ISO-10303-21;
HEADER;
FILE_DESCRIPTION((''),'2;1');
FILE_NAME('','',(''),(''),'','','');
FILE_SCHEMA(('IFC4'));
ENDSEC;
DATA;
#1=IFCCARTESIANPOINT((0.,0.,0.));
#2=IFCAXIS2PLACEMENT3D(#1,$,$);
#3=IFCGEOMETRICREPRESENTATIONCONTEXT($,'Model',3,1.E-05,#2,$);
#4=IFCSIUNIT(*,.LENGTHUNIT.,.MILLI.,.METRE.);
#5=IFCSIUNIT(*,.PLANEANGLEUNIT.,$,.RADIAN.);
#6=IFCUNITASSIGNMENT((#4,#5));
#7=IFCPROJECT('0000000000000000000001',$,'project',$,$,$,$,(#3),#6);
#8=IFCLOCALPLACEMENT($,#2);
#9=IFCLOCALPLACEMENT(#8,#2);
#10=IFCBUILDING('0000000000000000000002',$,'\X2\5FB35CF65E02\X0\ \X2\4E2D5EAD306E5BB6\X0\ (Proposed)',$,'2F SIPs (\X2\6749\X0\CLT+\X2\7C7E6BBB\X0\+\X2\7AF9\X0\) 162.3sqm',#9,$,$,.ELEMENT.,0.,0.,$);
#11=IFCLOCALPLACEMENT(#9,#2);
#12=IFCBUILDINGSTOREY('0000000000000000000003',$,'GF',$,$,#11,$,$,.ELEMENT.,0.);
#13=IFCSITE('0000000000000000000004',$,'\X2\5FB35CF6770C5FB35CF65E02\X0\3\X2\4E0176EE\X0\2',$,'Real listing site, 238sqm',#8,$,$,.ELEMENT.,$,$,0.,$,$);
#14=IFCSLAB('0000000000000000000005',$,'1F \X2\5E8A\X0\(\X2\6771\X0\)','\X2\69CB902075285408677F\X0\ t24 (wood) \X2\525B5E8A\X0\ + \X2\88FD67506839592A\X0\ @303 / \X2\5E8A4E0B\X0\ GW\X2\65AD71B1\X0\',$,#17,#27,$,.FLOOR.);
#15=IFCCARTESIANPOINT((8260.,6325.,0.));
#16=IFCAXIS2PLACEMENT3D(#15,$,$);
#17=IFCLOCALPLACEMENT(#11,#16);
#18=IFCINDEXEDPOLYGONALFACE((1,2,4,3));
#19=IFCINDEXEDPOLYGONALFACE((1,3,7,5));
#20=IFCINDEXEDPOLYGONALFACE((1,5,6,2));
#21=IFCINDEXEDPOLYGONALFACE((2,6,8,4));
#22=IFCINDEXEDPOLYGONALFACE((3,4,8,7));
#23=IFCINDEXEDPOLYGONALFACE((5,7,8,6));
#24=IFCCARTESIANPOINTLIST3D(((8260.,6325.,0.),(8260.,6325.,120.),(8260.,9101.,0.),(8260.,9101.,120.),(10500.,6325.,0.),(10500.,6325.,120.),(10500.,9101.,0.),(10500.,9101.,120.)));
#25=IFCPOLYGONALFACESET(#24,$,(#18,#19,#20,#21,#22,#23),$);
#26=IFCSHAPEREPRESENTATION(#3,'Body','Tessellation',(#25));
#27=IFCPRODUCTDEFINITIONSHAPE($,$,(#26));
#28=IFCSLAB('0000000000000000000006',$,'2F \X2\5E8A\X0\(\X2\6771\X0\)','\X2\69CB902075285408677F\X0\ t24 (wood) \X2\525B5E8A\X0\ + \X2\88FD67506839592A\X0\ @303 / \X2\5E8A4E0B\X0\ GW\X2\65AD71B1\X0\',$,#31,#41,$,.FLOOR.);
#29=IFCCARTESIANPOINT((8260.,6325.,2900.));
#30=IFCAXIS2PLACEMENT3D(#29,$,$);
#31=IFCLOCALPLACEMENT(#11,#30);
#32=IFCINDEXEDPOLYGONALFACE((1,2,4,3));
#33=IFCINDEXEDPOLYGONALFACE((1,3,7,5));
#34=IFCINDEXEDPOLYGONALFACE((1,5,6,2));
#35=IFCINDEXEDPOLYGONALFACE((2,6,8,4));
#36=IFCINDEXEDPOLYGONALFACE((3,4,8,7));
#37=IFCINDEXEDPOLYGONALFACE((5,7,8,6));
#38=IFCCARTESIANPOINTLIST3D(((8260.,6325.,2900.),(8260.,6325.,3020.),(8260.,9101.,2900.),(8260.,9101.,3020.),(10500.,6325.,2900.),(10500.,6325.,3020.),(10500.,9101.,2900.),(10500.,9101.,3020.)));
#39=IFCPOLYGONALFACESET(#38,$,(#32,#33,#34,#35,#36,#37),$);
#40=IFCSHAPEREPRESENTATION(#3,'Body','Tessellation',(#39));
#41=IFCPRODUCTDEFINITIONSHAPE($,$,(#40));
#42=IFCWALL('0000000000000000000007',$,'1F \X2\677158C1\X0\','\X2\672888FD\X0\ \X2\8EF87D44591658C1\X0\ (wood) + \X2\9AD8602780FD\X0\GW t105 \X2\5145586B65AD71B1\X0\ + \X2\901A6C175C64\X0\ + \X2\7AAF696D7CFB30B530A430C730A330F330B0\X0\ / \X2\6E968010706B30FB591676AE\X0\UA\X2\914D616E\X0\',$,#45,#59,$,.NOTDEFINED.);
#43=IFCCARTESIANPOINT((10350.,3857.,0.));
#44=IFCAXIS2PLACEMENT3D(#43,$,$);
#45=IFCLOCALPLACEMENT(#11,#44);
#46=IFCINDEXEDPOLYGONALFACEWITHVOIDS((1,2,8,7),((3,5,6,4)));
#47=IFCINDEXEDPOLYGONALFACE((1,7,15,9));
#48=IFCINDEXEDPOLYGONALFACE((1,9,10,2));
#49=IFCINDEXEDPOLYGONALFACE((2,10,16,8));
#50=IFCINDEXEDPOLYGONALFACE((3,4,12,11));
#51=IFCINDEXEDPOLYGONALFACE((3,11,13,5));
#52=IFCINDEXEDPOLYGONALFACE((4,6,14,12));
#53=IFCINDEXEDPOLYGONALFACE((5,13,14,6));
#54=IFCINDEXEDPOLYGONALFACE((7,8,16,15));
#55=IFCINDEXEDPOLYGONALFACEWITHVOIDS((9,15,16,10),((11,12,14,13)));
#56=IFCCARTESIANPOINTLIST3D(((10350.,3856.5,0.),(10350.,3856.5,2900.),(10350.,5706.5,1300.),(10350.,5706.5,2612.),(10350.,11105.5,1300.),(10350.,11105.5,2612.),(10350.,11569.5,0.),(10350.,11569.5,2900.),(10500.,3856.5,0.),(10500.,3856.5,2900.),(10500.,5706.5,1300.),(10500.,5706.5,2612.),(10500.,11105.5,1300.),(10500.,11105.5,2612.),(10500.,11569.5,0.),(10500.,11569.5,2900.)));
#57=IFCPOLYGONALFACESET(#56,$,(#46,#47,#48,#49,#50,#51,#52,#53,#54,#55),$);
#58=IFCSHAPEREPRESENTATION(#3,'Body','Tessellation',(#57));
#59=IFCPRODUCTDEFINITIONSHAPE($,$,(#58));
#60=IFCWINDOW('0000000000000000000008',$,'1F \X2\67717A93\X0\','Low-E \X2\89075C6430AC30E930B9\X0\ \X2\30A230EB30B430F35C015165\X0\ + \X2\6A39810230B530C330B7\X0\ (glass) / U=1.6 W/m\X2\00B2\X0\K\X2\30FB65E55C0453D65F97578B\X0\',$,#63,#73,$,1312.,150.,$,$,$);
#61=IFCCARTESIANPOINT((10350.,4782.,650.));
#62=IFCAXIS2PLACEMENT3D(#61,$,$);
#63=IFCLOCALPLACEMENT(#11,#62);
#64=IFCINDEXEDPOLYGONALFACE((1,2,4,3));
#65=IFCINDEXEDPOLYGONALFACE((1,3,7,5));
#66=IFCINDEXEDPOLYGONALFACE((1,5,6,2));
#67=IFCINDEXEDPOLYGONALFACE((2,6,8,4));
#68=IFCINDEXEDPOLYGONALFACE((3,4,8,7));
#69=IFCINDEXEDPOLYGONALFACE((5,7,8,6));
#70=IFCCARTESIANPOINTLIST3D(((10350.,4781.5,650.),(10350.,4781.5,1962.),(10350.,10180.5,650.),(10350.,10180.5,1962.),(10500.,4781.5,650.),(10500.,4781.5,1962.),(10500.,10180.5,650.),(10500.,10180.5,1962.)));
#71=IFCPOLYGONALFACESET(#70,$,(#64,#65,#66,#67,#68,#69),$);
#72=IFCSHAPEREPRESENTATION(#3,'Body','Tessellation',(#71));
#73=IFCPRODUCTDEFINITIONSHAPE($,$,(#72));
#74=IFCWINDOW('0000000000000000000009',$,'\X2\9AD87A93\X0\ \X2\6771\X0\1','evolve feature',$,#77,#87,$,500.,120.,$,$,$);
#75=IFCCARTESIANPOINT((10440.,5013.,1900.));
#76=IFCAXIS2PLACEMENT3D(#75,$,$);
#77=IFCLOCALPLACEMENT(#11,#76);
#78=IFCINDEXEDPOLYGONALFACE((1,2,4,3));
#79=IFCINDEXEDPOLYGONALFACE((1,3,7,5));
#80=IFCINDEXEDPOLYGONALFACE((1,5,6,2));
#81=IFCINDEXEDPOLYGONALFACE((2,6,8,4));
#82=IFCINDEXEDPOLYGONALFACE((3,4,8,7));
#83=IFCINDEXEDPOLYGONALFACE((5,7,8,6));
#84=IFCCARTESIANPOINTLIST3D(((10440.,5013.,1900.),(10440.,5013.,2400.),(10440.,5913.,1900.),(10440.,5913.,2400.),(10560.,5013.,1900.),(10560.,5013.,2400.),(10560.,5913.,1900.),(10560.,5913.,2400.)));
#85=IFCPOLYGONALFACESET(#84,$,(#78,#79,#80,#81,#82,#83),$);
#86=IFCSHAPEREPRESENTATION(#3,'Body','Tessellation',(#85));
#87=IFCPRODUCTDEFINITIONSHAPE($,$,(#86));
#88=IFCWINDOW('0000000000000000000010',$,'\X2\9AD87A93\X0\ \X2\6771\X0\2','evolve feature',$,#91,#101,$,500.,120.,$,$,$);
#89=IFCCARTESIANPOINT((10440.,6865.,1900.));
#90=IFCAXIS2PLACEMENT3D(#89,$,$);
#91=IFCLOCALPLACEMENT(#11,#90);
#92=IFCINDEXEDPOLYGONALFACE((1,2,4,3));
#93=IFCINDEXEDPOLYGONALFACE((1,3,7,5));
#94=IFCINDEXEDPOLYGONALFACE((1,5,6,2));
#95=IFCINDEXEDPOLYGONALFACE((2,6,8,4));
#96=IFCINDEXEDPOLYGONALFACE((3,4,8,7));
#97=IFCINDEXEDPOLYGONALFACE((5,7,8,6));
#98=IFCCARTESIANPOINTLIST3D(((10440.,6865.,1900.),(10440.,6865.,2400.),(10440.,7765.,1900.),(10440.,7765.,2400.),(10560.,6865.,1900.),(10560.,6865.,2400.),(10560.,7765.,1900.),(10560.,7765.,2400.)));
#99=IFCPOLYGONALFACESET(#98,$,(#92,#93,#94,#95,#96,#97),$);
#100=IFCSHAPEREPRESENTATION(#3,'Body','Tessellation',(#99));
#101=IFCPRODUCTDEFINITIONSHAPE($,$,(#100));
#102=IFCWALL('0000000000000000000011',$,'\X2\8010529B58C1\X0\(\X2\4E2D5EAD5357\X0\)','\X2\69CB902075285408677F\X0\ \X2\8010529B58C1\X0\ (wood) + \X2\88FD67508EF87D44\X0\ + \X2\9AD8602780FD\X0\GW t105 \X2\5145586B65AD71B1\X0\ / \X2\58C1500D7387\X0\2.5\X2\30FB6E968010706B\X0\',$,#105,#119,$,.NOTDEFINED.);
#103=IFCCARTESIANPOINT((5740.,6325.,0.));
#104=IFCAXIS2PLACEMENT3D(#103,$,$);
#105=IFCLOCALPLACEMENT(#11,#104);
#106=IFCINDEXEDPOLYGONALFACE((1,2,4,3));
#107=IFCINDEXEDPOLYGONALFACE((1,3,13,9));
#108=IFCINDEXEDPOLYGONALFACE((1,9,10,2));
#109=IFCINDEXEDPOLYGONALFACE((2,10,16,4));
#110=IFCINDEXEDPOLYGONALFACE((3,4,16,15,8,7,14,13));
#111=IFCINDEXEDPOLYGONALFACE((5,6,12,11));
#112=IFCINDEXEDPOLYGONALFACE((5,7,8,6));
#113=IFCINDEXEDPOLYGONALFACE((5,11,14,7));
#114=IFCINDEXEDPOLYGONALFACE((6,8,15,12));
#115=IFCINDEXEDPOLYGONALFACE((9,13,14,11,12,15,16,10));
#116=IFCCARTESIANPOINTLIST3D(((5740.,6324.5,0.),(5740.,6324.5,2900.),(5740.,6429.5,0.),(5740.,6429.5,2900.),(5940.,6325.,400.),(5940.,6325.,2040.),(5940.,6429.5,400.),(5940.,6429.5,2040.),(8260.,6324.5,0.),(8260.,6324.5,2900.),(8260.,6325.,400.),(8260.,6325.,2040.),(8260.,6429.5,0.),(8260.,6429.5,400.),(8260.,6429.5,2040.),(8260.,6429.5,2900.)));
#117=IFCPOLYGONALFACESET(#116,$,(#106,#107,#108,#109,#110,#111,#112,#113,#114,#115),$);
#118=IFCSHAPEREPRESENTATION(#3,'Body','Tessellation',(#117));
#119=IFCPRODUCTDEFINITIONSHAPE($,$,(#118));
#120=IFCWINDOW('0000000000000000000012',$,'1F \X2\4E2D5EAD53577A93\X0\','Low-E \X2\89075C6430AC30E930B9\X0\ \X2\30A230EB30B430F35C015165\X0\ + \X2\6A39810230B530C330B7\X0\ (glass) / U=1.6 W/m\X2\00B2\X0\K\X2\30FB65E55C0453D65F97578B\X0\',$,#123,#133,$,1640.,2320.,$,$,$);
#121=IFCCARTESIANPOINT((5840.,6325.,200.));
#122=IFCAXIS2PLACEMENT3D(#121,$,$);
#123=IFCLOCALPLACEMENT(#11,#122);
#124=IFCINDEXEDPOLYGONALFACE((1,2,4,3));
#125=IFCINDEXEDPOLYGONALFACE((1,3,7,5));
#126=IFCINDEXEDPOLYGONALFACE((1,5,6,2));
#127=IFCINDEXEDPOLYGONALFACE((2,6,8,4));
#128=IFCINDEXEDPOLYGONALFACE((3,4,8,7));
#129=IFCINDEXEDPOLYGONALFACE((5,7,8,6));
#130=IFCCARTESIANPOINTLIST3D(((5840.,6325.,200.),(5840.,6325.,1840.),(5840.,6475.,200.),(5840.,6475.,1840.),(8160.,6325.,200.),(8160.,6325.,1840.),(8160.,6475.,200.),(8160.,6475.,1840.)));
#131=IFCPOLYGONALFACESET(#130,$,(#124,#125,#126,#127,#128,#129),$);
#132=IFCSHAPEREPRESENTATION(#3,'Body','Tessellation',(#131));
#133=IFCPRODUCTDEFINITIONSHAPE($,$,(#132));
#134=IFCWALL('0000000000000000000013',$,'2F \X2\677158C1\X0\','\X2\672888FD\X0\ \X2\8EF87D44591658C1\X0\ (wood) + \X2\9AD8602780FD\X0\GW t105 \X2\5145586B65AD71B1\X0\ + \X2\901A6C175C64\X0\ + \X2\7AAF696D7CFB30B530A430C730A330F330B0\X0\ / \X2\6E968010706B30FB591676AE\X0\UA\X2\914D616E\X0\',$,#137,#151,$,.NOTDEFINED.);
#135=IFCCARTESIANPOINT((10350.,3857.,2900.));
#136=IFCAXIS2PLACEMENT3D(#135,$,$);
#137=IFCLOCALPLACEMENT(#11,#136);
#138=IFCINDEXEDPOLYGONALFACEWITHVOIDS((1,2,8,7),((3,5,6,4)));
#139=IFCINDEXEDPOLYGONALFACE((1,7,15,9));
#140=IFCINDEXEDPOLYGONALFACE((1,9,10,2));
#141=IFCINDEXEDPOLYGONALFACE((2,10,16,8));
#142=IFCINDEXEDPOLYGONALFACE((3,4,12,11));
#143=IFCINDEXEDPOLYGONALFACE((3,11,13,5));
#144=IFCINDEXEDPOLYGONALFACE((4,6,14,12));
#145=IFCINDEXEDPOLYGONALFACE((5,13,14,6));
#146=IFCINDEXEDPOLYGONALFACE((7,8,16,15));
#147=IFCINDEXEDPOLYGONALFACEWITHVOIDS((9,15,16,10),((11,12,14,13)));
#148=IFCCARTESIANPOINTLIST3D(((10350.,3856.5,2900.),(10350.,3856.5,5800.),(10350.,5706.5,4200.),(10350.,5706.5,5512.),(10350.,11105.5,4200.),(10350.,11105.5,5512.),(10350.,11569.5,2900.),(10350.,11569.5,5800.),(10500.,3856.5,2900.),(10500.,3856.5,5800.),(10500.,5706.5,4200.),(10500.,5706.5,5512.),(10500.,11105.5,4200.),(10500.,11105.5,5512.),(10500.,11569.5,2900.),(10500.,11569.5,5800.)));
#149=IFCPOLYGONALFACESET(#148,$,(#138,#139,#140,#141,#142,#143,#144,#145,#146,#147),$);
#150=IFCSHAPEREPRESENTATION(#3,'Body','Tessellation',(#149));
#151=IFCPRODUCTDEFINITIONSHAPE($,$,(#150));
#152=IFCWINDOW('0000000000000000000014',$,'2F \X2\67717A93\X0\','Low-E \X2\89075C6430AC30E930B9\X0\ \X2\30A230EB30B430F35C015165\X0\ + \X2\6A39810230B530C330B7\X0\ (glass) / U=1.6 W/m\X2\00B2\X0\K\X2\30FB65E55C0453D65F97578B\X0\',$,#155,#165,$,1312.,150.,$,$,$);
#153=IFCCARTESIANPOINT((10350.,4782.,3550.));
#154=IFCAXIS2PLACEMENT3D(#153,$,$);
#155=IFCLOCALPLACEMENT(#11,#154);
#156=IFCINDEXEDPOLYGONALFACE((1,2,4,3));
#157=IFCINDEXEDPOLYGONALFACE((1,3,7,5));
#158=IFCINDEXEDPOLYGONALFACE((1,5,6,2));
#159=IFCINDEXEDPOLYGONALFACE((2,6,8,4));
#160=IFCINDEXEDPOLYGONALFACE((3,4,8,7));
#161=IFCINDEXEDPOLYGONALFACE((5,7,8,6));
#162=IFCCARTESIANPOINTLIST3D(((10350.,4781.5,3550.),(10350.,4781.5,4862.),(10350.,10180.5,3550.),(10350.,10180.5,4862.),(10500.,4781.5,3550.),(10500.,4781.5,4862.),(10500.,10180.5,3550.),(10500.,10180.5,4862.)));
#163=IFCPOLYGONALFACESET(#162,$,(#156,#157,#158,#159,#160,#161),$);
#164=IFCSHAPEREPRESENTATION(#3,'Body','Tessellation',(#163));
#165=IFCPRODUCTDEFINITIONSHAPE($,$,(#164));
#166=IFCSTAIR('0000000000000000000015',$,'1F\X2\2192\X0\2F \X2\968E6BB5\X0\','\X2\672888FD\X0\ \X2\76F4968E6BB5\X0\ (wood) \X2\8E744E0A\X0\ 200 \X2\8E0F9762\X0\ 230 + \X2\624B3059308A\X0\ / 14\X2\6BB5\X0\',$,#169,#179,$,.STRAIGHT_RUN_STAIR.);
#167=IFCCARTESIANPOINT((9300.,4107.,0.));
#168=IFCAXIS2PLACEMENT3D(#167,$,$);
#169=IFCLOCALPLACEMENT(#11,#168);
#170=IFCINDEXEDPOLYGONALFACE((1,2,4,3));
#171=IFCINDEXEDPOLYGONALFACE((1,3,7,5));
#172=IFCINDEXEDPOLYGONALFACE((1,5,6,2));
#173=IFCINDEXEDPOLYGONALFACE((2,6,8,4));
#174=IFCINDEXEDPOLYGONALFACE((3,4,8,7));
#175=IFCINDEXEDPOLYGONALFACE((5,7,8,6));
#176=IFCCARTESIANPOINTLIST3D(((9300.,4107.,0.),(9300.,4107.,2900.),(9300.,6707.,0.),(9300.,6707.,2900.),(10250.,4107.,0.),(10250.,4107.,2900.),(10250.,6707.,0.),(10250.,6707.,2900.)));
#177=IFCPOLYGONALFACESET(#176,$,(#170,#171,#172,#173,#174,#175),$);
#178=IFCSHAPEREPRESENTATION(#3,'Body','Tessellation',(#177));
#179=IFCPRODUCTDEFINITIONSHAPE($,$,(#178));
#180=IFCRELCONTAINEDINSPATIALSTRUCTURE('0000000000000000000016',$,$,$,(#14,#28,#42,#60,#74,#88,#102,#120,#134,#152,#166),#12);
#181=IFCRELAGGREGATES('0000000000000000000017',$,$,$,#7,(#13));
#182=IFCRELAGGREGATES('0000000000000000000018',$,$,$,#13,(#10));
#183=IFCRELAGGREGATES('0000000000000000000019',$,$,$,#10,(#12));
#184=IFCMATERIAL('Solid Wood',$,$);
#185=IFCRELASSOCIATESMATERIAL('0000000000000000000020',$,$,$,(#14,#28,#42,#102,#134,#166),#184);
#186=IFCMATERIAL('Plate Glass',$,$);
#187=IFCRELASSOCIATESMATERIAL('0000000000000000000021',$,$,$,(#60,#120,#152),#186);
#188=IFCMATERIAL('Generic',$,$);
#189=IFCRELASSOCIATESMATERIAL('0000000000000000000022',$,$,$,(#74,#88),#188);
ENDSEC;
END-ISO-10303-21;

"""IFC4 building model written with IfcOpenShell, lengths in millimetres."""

from ifc_helpers import new_model, si_unit, frame, frame_2d, origin, place, context, project, spatial, rectangle, extrude, material, element, fill, save


model = new_model("IFC4")

# Units and contexts
model_context = context("Model", 3, precision=1e-05, world=origin())
ifc_project = project(units=[si_unit("LENGTHUNIT", "METRE", prefix="MILLI"), si_unit("PLANEANGLEUNIT", "RADIAN")], contexts=[model_context])

# Site, building, storey
site_placement = place(None, origin())
site = spatial("IfcSite", under=ifc_project, at=site_placement, Name="徳島県徳島市3丁目2", ObjectType="Real listing site, 238sqm", CompositionType="ELEMENT", RefElevation=0.0)
building_placement = place(site_placement, origin())
building = spatial("IfcBuilding", under=site, at=building_placement, Name="徳島市 中庭の家 (Proposed)", ObjectType="2F SIPs (杉CLT+籾殻+竹) 162.3sqm", CompositionType="ELEMENT", ElevationOfRefHeight=0.0, ElevationOfTerrain=0.0)
storey_placement = place(building_placement, origin())
storey = spatial("IfcBuildingStorey", under=building, at=storey_placement, Name="GF", CompositionType="ELEMENT", Elevation=0.0)

# Slabs
ifc_material_1 = material(Name="Solid Wood")
slab_1_placement = place(storey_placement, frame((8260.0, 6325.0, 0.0)))
element("IfcSlab", 1, at=slab_1_placement, inside=storey, material=ifc_material_1, Name="1F 床(東)", Description="構造用合板 t24 (wood) 剛床 + 製材根太 @303 / 床下 GW断熱", PredefinedType="FLOOR", context=model_context, shape_type="SweptSolid", body=[
    extrude(rectangle(XDim=2240.0, YDim=2776.0, at=frame_2d((1120.0, 1388.0))), frame((8260.0, 6325.0, 0.0)), (0.0, 0.0, 1.0), 120.0),
])
slab_2_placement = place(storey_placement, frame((8260.0, 6325.0, 2900.0)))
element("IfcSlab", 2, at=slab_2_placement, inside=storey, material=ifc_material_1, Name="2F 床(東)", Description="構造用合板 t24 (wood) 剛床 + 製材根太 @303 / 床下 GW断熱", PredefinedType="FLOOR", context=model_context, shape_type="SweptSolid", body=[
    extrude(rectangle(XDim=2240.0, YDim=2776.0, at=frame_2d((1120.0, 1388.0))), frame((8260.0, 6325.0, 2900.0)), (0.0, 0.0, 1.0), 120.0),
])

# Wall, openings, windows
wall_1_placement = place(storey_placement, frame((10350.0, 3857.0, 0.0)))
wall_1 = element("IfcWall", 3, at=wall_1_placement, inside=storey, material=ifc_material_1, Name="1F 東壁", Description="木製 軸組外壁 (wood) + 高性能GW t105 充填断熱 + 通気層 + 窯業系サイディング / 準耐火・外皮UA配慮", PredefinedType="NOTDEFINED", context=model_context, shape_type="SweptSolid", body=[
    extrude(rectangle(XDim=150.0, YDim=7713.0, at=frame_2d((75.0, 3856.0))), frame((10350.0, 3857.0, 0.0)), (0.0, 0.0, 1.0), 2900.0),
])
opening_1_placement = place(storey_placement, frame((10350.0, 4782.0, 650.0)))
opening_1 = element("IfcOpeningElement", 4, at=opening_1_placement, cuts=wall_1, PredefinedType="NOTDEFINED", context=model_context, shape_type="SweptSolid", body=[
    extrude(rectangle(XDim=150.0, YDim=5399.0, at=frame_2d((75.0, 2699.0))), frame((10350.0, 4782.0, 650.0)), (0.0, 0.0, 1.0), 1312.0),
])
opening_2_placement = place(storey_placement, frame((10440.0, 5013.0, 1900.0)))
opening_2 = element("IfcOpeningElement", 5, at=opening_2_placement, cuts=wall_1, PredefinedType="NOTDEFINED", context=model_context, shape_type="SweptSolid", body=[
    extrude(rectangle(XDim=120.0, YDim=900.0, at=frame_2d((60.0, 450.0))), frame((10440.0, 5013.0, 1900.0)), (0.0, 0.0, 1.0), 500.0),
])
opening_3_placement = place(storey_placement, frame((10440.0, 6865.0, 1900.0)))
opening_3 = element("IfcOpeningElement", 6, at=opening_3_placement, cuts=wall_1, PredefinedType="NOTDEFINED", context=model_context, shape_type="SweptSolid", body=[
    extrude(rectangle(XDim=120.0, YDim=900.0, at=frame_2d((60.0, 450.0))), frame((10440.0, 6865.0, 1900.0)), (0.0, 0.0, 1.0), 500.0),
])
ifc_material_2 = material(Name="Plate Glass")
window_1_placement = place(storey_placement, frame((10350.0, 4782.0, 650.0)))
window_1 = element("IfcWindow", 7, at=window_1_placement, inside=storey, material=ifc_material_2, Name="1F 東窓", Description="Low-E 複層ガラス アルゴン封入 + 樹脂サッシ (glass) / U=1.6 W/m²K・日射取得型", OverallHeight=1312.0, OverallWidth=150.0, context=model_context, shape_type="SweptSolid", body=[
    extrude(rectangle(XDim=150.0, YDim=5399.0, at=frame_2d((75.0, 2699.0))), frame((10350.0, 4782.0, 650.0)), (0.0, 0.0, 1.0), 1312.0),
])
fill(opening_1, window_1)
ifc_material_3 = material(Name="Generic")
window_2_placement = place(storey_placement, frame((10440.0, 5013.0, 1900.0)))
window_2 = element("IfcWindow", 8, at=window_2_placement, inside=storey, material=ifc_material_3, Name="高窓 東1", Description="evolve feature", OverallHeight=500.0, OverallWidth=120.0, context=model_context, shape_type="SweptSolid", body=[
    extrude(rectangle(XDim=120.0, YDim=900.0, at=frame_2d((60.0, 450.0))), frame((10440.0, 5013.0, 1900.0)), (0.0, 0.0, 1.0), 500.0),
])
fill(opening_2, window_2)
window_3_placement = place(storey_placement, frame((10440.0, 6865.0, 1900.0)))
window_3 = element("IfcWindow", 9, at=window_3_placement, inside=storey, material=ifc_material_3, Name="高窓 東2", Description="evolve feature", OverallHeight=500.0, OverallWidth=120.0, context=model_context, shape_type="SweptSolid", body=[
    extrude(rectangle(XDim=120.0, YDim=900.0, at=frame_2d((60.0, 450.0))), frame((10440.0, 6865.0, 1900.0)), (0.0, 0.0, 1.0), 500.0),
])
fill(opening_3, window_3)

# Wall, opening, window
wall_2_placement = place(storey_placement, frame((5740.0, 6325.0, 0.0)))
wall_2 = element("IfcWall", 10, at=wall_2_placement, inside=storey, material=ifc_material_1, Name="耐力壁(中庭南)", Description="構造用合板 耐力壁 (wood) + 製材軸組 + 高性能GW t105 充填断熱 / 壁倍率2.5・準耐火", PredefinedType="NOTDEFINED", context=model_context, shape_type="SweptSolid", body=[
    extrude(rectangle(XDim=2520.0, YDim=105.0, at=frame_2d((1260.0, 52.0))), frame((5740.0, 6325.0, 0.0)), (0.0, 0.0, 1.0), 2900.0),
])
opening_4_placement = place(storey_placement, frame((5840.0, 6325.0, 200.0)))
opening_4 = element("IfcOpeningElement", 11, at=opening_4_placement, cuts=wall_2, PredefinedType="NOTDEFINED", context=model_context, shape_type="SweptSolid", body=[
    extrude(rectangle(XDim=2320.0, YDim=150.0, at=frame_2d((1160.0, 75.0))), frame((5840.0, 6325.0, 200.0)), (0.0, 0.0, 1.0), 1640.0),
])
window_4_placement = place(storey_placement, frame((5840.0, 6325.0, 200.0)))
window_4 = element("IfcWindow", 12, at=window_4_placement, inside=storey, material=ifc_material_2, Name="1F 中庭南窓", Description="Low-E 複層ガラス アルゴン封入 + 樹脂サッシ (glass) / U=1.6 W/m²K・日射取得型", OverallHeight=1640.0, OverallWidth=2320.0, context=model_context, shape_type="SweptSolid", body=[
    extrude(rectangle(XDim=2320.0, YDim=150.0, at=frame_2d((1160.0, 75.0))), frame((5840.0, 6325.0, 200.0)), (0.0, 0.0, 1.0), 1640.0),
])
fill(opening_4, window_4)

# Wall, opening, window
wall_3_placement = place(storey_placement, frame((10350.0, 3857.0, 2900.0)))
wall_3 = element("IfcWall", 13, at=wall_3_placement, inside=storey, material=ifc_material_1, Name="2F 東壁", Description="木製 軸組外壁 (wood) + 高性能GW t105 充填断熱 + 通気層 + 窯業系サイディング / 準耐火・外皮UA配慮", PredefinedType="NOTDEFINED", context=model_context, shape_type="SweptSolid", body=[
    extrude(rectangle(XDim=150.0, YDim=7713.0, at=frame_2d((75.0, 3856.0))), frame((10350.0, 3857.0, 2900.0)), (0.0, 0.0, 1.0), 2900.0),
])
opening_5_placement = place(storey_placement, frame((10350.0, 4782.0, 3550.0)))
opening_5 = element("IfcOpeningElement", 14, at=opening_5_placement, cuts=wall_3, PredefinedType="NOTDEFINED", context=model_context, shape_type="SweptSolid", body=[
    extrude(rectangle(XDim=150.0, YDim=5399.0, at=frame_2d((75.0, 2699.0))), frame((10350.0, 4782.0, 3550.0)), (0.0, 0.0, 1.0), 1312.0),
])
window_5_placement = place(storey_placement, frame((10350.0, 4782.0, 3550.0)))
window_5 = element("IfcWindow", 15, at=window_5_placement, inside=storey, material=ifc_material_2, Name="2F 東窓", Description="Low-E 複層ガラス アルゴン封入 + 樹脂サッシ (glass) / U=1.6 W/m²K・日射取得型", OverallHeight=1312.0, OverallWidth=150.0, context=model_context, shape_type="SweptSolid", body=[
    extrude(rectangle(XDim=150.0, YDim=5399.0, at=frame_2d((75.0, 2699.0))), frame((10350.0, 4782.0, 3550.0)), (0.0, 0.0, 1.0), 1312.0),
])
fill(opening_5, window_5)

# Stair
stair_placement = place(storey_placement, frame((9300.0, 4107.0, 0.0)))
element("IfcStair", 16, at=stair_placement, inside=storey, material=ifc_material_1, Name="1F→2F 階段", Description="木製 直階段 (wood) 蹴上 200 踏面 230 + 手すり / 14段", PredefinedType="STRAIGHT_RUN_STAIR", context=model_context, shape_type="SweptSolid", body=[
    extrude(rectangle(XDim=950.0, YDim=2600.0, at=frame_2d((475.0, 1300.0))), frame((9300.0, 4107.0, 0.0)), (0.0, 0.0, 1.0), 2900.0),
])

save(model, "model.ifc")
